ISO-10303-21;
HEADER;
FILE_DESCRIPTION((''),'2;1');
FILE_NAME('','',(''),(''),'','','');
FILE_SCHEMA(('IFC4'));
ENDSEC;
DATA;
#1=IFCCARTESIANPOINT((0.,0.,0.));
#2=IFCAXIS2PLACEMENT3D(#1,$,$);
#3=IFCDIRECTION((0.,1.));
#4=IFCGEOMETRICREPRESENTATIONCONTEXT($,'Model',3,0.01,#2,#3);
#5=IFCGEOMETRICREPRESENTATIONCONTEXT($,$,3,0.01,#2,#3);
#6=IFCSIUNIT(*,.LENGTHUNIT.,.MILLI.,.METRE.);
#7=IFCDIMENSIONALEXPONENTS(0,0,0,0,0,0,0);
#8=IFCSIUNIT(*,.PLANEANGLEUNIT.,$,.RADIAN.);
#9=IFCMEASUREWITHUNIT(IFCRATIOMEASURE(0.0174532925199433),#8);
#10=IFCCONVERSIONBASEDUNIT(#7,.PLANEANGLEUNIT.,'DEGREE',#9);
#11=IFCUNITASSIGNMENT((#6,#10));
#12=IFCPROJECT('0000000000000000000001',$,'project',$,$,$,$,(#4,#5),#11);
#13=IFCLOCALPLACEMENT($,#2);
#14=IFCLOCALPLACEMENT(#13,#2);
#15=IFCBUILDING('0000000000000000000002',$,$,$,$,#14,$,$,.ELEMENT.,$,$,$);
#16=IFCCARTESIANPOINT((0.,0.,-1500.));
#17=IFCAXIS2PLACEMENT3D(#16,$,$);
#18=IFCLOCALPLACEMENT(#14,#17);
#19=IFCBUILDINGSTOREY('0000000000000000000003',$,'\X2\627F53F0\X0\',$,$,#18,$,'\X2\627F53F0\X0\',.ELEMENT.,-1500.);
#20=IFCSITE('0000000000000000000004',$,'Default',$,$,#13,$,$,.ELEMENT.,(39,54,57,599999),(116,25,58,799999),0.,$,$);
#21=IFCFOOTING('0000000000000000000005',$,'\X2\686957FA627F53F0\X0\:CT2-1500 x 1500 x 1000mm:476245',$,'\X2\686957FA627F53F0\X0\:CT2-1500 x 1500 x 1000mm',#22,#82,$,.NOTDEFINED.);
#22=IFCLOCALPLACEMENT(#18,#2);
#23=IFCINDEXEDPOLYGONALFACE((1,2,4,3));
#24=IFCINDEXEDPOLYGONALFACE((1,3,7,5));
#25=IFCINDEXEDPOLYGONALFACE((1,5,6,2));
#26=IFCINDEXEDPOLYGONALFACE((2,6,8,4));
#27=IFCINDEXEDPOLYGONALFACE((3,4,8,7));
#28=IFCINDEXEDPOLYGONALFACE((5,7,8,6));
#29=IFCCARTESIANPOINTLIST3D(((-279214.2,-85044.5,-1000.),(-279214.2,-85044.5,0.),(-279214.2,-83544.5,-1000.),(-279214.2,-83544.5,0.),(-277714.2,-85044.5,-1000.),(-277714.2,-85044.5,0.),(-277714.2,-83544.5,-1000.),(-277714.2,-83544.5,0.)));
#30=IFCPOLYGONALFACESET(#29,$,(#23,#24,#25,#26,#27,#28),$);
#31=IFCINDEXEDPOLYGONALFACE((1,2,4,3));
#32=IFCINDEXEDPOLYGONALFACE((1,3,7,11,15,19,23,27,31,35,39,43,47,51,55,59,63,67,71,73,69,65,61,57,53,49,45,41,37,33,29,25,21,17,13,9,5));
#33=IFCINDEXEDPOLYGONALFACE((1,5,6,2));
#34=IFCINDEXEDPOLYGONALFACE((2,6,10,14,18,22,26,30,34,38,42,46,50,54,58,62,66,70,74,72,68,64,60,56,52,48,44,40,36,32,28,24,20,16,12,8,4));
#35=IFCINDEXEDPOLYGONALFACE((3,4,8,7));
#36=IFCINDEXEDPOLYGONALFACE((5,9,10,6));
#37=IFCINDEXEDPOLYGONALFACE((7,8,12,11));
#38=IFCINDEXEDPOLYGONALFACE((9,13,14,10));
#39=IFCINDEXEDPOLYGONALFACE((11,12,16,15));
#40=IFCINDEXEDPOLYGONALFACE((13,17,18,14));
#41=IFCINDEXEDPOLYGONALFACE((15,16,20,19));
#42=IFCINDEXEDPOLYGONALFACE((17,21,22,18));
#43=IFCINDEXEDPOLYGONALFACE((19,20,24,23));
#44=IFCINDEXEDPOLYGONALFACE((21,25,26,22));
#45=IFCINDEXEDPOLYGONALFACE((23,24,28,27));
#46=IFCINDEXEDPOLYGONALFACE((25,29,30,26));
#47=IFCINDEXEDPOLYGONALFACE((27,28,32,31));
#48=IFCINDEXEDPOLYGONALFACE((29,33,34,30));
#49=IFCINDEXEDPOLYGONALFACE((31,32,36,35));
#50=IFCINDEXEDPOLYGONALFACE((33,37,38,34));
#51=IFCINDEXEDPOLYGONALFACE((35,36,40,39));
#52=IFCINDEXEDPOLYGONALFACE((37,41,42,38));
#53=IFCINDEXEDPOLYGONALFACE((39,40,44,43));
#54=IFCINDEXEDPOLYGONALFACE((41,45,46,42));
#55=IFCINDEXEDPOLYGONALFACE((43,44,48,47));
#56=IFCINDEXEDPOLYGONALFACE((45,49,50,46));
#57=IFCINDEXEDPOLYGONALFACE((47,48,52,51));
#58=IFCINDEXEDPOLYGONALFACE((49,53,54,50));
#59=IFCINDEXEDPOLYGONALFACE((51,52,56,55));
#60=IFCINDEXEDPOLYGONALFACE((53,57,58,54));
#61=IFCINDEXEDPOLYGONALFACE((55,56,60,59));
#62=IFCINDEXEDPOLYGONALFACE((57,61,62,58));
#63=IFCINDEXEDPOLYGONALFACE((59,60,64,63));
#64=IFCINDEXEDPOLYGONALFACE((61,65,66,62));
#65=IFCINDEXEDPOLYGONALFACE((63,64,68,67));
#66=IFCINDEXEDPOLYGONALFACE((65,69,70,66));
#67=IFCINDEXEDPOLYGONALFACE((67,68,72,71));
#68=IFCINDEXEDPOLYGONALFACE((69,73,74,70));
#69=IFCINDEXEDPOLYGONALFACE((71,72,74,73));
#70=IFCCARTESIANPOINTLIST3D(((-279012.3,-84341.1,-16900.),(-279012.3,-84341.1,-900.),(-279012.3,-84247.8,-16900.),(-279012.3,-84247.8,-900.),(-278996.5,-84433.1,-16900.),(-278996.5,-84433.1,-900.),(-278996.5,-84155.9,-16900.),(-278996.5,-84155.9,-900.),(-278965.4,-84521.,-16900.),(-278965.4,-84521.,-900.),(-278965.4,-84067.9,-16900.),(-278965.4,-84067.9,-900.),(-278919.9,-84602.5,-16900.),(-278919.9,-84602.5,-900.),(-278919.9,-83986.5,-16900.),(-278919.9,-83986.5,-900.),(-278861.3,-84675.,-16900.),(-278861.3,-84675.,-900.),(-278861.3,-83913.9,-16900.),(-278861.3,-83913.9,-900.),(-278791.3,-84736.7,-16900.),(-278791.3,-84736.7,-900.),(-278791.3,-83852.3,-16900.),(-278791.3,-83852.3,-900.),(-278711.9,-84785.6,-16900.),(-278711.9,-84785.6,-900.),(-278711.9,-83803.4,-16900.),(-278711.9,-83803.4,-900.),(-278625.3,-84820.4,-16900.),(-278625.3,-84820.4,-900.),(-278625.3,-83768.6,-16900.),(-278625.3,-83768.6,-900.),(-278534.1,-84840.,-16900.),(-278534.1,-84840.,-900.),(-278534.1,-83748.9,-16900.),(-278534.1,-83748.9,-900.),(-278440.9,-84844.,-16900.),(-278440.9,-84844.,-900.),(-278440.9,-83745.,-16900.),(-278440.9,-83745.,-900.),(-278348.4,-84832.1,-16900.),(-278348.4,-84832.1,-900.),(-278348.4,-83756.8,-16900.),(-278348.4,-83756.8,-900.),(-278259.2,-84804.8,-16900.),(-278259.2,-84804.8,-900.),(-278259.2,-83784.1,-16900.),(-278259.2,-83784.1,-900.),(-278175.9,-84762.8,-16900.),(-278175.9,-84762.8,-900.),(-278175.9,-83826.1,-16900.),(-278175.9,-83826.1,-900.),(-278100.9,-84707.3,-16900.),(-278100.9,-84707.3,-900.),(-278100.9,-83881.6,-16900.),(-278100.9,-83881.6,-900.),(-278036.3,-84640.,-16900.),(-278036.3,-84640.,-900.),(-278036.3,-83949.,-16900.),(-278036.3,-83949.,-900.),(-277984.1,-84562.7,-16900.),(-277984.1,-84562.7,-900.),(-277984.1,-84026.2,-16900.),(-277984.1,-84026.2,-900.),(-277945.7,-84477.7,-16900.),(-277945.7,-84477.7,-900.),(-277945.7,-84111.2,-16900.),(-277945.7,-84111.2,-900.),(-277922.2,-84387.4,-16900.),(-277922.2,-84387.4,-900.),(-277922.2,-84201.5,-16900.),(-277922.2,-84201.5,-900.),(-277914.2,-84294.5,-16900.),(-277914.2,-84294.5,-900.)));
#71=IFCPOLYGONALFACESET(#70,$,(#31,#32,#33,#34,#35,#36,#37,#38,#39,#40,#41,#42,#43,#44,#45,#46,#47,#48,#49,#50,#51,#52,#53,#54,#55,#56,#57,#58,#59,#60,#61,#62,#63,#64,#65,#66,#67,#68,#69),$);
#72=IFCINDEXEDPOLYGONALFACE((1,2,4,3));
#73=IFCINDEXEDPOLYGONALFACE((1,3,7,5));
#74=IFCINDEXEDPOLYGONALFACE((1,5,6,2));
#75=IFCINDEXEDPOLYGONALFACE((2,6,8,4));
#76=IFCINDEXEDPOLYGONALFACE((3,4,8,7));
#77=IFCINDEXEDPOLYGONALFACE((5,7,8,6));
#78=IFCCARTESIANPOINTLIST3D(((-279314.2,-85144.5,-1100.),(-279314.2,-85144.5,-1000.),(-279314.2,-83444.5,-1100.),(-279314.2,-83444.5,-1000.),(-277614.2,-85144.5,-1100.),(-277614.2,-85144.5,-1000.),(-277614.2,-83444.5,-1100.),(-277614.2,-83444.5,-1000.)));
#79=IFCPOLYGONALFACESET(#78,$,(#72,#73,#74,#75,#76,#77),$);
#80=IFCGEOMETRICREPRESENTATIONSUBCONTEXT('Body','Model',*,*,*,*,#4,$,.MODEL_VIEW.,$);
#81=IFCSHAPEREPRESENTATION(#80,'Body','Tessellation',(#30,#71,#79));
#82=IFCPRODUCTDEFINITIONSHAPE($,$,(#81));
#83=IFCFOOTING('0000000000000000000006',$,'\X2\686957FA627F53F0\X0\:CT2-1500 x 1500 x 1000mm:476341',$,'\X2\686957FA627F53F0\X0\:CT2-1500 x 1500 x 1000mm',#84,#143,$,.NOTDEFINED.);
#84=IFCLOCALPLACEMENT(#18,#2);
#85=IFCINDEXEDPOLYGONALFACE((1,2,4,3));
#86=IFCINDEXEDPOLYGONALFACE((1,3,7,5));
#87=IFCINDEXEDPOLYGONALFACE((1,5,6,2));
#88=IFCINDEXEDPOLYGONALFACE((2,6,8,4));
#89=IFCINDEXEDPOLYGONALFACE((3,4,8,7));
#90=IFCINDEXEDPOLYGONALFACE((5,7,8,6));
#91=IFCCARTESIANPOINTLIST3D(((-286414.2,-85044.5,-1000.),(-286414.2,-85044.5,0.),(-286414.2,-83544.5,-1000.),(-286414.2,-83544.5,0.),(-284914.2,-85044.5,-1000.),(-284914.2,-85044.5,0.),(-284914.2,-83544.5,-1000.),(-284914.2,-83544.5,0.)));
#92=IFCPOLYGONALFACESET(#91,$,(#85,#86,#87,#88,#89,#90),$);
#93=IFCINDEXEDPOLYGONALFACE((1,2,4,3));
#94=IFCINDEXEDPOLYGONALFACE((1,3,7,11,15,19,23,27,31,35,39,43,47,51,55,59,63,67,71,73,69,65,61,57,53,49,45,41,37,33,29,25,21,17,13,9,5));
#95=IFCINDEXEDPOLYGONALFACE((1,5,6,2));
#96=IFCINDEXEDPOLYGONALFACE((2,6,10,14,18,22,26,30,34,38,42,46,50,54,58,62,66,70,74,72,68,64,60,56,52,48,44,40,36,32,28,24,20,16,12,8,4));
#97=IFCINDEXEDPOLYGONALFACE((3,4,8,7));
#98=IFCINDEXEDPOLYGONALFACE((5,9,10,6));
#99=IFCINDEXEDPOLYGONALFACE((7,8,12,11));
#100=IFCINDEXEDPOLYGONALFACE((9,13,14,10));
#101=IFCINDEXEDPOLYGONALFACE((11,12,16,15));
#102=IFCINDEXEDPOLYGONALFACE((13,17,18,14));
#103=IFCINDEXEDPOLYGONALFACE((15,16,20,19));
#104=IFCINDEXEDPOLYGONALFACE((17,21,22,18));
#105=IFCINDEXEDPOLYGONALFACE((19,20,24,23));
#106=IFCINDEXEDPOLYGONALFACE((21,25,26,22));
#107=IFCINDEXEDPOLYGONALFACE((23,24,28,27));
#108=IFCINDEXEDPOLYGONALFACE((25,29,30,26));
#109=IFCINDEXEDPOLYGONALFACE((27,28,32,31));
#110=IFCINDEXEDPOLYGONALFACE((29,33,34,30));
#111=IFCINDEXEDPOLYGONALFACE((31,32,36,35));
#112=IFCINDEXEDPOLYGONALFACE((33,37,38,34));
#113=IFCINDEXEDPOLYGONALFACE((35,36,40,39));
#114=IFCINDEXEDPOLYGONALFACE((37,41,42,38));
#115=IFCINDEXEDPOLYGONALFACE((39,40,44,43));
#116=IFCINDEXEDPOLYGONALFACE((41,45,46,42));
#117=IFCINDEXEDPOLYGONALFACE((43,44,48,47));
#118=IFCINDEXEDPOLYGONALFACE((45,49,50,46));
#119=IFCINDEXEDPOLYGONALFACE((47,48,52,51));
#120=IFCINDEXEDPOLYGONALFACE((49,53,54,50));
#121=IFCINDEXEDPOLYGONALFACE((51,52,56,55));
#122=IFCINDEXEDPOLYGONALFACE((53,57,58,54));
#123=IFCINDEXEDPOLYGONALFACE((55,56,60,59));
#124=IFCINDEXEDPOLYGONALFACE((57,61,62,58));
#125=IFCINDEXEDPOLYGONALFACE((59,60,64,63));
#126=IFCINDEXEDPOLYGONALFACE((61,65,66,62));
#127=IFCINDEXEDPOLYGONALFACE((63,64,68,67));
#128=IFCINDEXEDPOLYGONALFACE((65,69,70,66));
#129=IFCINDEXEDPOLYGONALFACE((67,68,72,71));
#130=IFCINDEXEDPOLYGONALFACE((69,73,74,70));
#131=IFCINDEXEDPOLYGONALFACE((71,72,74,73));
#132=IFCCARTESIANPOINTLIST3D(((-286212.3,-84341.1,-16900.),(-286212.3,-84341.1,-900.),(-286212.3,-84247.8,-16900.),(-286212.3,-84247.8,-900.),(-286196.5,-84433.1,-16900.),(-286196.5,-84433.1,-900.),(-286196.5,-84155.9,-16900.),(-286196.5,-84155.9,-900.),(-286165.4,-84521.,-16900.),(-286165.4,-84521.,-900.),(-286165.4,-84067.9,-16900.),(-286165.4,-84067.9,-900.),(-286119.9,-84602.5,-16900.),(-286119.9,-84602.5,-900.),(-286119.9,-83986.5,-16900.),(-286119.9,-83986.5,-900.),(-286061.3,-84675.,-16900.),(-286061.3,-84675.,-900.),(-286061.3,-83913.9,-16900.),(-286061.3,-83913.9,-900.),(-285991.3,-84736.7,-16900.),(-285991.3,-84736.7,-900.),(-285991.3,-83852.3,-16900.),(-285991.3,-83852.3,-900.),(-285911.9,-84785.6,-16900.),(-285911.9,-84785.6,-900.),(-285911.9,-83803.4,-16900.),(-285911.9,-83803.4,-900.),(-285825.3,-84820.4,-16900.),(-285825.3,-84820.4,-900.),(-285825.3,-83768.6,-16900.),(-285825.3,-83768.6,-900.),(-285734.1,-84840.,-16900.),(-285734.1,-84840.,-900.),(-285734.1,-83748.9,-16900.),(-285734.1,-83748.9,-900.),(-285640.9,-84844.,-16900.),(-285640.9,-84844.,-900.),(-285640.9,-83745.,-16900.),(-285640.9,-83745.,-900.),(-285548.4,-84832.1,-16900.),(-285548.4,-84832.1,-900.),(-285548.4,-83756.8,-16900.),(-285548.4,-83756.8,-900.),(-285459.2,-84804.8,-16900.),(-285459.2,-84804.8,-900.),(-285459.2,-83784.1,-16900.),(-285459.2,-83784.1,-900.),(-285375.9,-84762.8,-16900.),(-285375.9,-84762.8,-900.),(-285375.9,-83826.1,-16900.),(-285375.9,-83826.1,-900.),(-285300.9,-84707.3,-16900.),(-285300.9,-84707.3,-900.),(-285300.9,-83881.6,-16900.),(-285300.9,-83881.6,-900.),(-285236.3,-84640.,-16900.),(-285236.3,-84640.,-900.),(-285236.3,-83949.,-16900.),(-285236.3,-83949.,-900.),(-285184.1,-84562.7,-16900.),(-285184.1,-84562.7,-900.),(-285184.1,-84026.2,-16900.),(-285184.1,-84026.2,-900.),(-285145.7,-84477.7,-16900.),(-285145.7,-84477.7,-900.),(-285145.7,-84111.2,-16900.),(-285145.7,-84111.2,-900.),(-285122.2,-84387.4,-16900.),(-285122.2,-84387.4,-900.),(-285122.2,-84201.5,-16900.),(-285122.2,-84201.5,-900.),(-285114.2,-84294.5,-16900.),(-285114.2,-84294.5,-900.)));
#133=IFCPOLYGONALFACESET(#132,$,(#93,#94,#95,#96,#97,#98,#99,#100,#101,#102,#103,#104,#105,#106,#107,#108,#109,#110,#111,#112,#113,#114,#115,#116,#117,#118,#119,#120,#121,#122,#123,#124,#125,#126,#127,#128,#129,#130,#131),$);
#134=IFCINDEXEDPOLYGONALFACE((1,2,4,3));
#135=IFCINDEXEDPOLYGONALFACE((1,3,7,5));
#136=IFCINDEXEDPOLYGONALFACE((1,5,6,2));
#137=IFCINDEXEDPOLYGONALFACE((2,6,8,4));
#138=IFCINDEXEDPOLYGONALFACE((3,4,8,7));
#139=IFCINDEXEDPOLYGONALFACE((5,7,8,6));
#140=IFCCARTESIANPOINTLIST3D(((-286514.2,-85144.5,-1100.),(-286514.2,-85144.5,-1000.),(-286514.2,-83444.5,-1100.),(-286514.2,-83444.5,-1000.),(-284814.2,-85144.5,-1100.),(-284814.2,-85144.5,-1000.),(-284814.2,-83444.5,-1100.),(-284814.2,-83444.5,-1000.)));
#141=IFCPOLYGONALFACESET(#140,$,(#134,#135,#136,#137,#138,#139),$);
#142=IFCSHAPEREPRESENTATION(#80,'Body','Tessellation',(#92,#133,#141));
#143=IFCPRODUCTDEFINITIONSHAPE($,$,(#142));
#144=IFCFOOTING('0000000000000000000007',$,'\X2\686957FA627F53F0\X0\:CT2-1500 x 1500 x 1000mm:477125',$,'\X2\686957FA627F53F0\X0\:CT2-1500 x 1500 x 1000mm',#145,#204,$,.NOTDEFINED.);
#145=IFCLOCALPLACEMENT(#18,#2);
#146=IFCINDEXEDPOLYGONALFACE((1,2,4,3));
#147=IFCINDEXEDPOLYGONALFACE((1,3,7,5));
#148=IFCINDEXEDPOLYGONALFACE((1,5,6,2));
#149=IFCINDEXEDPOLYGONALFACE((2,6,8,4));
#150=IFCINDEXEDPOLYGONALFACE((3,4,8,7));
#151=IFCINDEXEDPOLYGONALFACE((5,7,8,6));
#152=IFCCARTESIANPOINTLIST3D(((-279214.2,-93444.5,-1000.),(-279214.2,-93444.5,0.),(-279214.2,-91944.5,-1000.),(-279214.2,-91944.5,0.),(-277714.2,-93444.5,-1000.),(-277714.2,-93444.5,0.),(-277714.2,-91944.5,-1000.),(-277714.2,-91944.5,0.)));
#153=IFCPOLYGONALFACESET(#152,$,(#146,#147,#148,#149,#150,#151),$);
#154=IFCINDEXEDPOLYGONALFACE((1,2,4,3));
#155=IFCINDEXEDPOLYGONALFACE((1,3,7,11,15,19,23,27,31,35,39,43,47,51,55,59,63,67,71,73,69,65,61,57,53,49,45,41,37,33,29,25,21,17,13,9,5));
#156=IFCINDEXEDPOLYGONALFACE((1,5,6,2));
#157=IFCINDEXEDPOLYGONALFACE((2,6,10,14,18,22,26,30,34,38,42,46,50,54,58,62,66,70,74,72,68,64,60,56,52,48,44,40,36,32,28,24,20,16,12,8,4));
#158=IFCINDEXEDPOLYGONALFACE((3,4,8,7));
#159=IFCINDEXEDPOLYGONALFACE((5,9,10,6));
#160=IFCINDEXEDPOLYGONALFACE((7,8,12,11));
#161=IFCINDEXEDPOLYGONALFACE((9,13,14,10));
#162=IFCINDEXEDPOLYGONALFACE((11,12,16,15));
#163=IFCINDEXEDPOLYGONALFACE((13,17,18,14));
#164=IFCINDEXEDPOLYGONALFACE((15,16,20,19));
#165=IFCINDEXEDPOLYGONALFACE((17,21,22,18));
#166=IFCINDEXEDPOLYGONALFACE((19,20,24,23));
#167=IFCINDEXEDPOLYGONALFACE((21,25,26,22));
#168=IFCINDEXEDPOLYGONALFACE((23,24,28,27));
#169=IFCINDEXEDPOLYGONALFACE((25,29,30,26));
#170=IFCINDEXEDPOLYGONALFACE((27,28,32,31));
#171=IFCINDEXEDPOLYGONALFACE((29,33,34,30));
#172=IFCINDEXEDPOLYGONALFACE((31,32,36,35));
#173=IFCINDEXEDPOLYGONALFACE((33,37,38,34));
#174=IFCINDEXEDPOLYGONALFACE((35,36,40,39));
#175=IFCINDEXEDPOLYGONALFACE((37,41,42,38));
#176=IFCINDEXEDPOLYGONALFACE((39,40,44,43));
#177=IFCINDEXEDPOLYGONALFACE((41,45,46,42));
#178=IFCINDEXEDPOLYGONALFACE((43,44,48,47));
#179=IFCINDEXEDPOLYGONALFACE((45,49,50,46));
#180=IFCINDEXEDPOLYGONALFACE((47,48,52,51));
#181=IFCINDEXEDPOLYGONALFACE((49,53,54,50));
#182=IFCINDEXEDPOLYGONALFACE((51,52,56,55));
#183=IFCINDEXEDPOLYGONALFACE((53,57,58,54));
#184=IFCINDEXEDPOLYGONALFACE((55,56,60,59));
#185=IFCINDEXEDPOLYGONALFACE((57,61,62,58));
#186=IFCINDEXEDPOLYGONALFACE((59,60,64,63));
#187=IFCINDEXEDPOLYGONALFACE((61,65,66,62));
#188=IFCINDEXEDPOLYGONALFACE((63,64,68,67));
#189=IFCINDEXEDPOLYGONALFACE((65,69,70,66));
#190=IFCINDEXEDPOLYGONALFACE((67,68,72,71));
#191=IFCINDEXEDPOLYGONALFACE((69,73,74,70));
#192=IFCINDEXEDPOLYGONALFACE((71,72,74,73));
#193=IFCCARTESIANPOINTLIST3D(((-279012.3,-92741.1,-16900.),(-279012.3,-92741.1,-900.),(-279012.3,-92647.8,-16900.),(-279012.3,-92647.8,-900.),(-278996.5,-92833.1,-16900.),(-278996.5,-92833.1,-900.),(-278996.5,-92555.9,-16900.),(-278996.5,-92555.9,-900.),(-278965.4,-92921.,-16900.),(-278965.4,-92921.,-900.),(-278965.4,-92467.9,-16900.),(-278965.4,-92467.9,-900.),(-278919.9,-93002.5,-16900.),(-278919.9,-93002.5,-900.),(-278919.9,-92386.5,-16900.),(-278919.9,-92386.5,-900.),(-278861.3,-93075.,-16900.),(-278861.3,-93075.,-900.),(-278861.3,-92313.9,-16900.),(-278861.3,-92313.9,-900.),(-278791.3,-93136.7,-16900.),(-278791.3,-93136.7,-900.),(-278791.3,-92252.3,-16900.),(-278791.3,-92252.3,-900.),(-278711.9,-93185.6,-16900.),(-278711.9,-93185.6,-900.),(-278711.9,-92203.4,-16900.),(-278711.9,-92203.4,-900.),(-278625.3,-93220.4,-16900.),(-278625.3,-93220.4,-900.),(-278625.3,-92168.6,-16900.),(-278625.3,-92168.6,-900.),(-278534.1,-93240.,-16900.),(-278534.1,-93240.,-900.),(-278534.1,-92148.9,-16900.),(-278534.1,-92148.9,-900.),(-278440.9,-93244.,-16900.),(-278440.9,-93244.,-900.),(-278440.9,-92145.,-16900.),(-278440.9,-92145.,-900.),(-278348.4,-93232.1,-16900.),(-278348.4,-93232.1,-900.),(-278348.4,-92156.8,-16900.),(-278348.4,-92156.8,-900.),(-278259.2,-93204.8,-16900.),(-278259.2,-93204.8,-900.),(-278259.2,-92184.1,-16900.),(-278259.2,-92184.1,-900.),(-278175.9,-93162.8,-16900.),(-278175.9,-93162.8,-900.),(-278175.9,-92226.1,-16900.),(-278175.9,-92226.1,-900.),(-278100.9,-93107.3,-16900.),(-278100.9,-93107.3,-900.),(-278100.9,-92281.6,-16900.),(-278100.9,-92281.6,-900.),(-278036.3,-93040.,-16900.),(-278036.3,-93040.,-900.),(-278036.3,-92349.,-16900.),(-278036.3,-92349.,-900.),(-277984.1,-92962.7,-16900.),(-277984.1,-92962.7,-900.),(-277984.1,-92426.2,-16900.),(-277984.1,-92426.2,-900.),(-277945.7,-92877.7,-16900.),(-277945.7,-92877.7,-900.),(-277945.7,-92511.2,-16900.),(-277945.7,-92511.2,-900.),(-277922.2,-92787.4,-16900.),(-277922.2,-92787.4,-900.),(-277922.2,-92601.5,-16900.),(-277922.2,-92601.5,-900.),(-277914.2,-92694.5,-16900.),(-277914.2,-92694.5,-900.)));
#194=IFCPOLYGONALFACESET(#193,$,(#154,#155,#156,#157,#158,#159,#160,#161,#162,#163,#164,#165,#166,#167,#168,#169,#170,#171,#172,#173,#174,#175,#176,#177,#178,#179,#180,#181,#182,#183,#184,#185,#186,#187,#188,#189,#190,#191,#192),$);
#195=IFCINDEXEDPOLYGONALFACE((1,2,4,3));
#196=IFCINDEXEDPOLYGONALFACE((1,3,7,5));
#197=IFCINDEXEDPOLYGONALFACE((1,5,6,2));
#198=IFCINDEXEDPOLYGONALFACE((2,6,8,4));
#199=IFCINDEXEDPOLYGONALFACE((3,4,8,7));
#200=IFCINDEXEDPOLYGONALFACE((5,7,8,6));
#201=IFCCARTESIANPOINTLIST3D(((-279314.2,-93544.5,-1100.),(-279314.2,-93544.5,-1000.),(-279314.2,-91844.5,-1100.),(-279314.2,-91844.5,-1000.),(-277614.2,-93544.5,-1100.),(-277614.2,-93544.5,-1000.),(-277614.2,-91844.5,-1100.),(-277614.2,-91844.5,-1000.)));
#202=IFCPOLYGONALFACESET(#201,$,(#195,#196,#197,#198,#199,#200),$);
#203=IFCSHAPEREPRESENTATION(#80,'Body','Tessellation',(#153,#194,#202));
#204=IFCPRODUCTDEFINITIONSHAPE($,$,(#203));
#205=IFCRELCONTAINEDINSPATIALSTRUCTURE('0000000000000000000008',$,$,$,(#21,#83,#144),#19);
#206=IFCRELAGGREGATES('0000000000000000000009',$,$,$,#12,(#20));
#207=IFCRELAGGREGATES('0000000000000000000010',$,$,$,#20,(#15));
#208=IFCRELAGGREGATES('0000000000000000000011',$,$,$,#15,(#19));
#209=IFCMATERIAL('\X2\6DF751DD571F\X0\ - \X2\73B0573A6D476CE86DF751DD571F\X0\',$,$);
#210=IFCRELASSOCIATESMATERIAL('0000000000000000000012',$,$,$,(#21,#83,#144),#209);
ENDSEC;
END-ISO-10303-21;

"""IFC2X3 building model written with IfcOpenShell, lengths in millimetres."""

from ifc_helpers import new_model, entity, si_unit, converted_unit, direction, frame, frame_2d, origin, origin_2d_with_axis, place, context, subcontext, project, spatial, rectangle, circle, extrude, material, element, save


model = new_model("IFC2X3")

# Units and contexts
model_context = context("Model", 3, precision=0.01, world=origin(), true_north=direction((0.0, 1.0)))
context_of_model = context(None, 3, precision=0.01, world=origin(), true_north=direction((0.0, 1.0)))
body_context = subcontext(model_context, "Body", "Model", "MODEL_VIEW")
ifc_project = project(units=[si_unit("LENGTHUNIT", "METRE", prefix="MILLI"), converted_unit("PLANEANGLEUNIT", "DEGREE", entity("IfcRatioMeasure", 0.0174532925199433), si_unit("PLANEANGLEUNIT", "RADIAN"), dimensions=[0, 0, 0, 0, 0, 0, 0])], contexts=[model_context, context_of_model])

# Site, building, storey
site_placement = place(None, origin())
site = spatial("IfcSite", under=ifc_project, at=site_placement, Name="Default", CompositionType="ELEMENT", RefLatitude=(39, 54, 57, 599999), RefLongitude=(116, 25, 58, 799999), RefElevation=0.0)
building_placement = place(site_placement, origin())
building = spatial("IfcBuilding", under=site, at=building_placement, CompositionType="ELEMENT")
storey_placement = place(building_placement, frame((0.0, 0.0, -1500.0)))
storey = spatial("IfcBuildingStorey", under=building, at=storey_placement, Name="承台", LongName="承台", CompositionType="ELEMENT", Elevation=-1500.0)

# Footings
ifc_material_1 = material(Name="混凝土 - 现场浇注混凝土")
footing_1_placement = place(storey_placement, frame((-279314.2, -85144.5, -16900.0)))
element("IfcFooting", 1, at=footing_1_placement, inside=storey, material=ifc_material_1, Name="桩基承台:CT2-1500 x 1500 x 1000mm:476245", ObjectType="桩基承台:CT2-1500 x 1500 x 1000mm", PredefinedType="NOTDEFINED", context=body_context, shape_type="SweptSolid", body=[
    extrude(rectangle(XDim=1500.0, YDim=1500.0, at=origin_2d_with_axis()), frame((850.0, 850.0, 15900.0), z_axis=(0.0, 0.0, 1.0), x_axis=(-1.0, 0.0, 0.0)), (0.0, 0.0, 1.0), 1000.0),
    extrude(circle(Radius=550.0, at=origin_2d_with_axis()), frame((850.0, 850.0, 0.0)), (0.0, 0.0, 1.0), 16000.0),
    extrude(rectangle(XDim=1700.0, YDim=1700.0, at=frame_2d((0.0, 0.0), x_axis=(1.0, 0.0))), frame((850.0, 850.0, 15800.0), z_axis=(0.0, 0.0, 1.0), x_axis=(0.0, 1.0, 0.0)), (0.0, 0.0, 1.0), 100.0),
])
for number, where, name in (
    (2, (-286514.2, -85144.5, -16900.0), "桩基承台:CT2-1500 x 1500 x 1000mm:476341"),
    (3, (-279314.2, -93544.5, -16900.0), "桩基承台:CT2-1500 x 1500 x 1000mm:477125"),
):
    element("IfcFooting", number, at=place(storey_placement, frame(where)), inside=storey, material=ifc_material_1, Name=name, ObjectType="桩基承台:CT2-1500 x 1500 x 1000mm", PredefinedType="NOTDEFINED", context=body_context, shape_type="SweptSolid", body=[
        extrude(rectangle(XDim=1500.0, YDim=1500.0, at=origin_2d_with_axis()), frame((850.0, 850.0, 15900.0), z_axis=(0.0, 0.0, 1.0), x_axis=(-1.0, 0.0, 0.0)), (0.0, 0.0, 1.0), 1000.0),
        extrude(circle(Radius=550.0, at=origin_2d_with_axis()), frame((850.0, 850.0, 0.0)), (0.0, 0.0, 1.0), 16000.0),
        extrude(rectangle(XDim=1700.0, YDim=1700.0, at=frame_2d((0.0, 0.0), x_axis=(1.0, 0.0))), frame((850.0, 850.0, 15800.0), z_axis=(0.0, 0.0, 1.0), x_axis=(0.0, 1.0, 0.0)), (0.0, 0.0, 1.0), 100.0),
    ])

save(model, "model.ifc")
